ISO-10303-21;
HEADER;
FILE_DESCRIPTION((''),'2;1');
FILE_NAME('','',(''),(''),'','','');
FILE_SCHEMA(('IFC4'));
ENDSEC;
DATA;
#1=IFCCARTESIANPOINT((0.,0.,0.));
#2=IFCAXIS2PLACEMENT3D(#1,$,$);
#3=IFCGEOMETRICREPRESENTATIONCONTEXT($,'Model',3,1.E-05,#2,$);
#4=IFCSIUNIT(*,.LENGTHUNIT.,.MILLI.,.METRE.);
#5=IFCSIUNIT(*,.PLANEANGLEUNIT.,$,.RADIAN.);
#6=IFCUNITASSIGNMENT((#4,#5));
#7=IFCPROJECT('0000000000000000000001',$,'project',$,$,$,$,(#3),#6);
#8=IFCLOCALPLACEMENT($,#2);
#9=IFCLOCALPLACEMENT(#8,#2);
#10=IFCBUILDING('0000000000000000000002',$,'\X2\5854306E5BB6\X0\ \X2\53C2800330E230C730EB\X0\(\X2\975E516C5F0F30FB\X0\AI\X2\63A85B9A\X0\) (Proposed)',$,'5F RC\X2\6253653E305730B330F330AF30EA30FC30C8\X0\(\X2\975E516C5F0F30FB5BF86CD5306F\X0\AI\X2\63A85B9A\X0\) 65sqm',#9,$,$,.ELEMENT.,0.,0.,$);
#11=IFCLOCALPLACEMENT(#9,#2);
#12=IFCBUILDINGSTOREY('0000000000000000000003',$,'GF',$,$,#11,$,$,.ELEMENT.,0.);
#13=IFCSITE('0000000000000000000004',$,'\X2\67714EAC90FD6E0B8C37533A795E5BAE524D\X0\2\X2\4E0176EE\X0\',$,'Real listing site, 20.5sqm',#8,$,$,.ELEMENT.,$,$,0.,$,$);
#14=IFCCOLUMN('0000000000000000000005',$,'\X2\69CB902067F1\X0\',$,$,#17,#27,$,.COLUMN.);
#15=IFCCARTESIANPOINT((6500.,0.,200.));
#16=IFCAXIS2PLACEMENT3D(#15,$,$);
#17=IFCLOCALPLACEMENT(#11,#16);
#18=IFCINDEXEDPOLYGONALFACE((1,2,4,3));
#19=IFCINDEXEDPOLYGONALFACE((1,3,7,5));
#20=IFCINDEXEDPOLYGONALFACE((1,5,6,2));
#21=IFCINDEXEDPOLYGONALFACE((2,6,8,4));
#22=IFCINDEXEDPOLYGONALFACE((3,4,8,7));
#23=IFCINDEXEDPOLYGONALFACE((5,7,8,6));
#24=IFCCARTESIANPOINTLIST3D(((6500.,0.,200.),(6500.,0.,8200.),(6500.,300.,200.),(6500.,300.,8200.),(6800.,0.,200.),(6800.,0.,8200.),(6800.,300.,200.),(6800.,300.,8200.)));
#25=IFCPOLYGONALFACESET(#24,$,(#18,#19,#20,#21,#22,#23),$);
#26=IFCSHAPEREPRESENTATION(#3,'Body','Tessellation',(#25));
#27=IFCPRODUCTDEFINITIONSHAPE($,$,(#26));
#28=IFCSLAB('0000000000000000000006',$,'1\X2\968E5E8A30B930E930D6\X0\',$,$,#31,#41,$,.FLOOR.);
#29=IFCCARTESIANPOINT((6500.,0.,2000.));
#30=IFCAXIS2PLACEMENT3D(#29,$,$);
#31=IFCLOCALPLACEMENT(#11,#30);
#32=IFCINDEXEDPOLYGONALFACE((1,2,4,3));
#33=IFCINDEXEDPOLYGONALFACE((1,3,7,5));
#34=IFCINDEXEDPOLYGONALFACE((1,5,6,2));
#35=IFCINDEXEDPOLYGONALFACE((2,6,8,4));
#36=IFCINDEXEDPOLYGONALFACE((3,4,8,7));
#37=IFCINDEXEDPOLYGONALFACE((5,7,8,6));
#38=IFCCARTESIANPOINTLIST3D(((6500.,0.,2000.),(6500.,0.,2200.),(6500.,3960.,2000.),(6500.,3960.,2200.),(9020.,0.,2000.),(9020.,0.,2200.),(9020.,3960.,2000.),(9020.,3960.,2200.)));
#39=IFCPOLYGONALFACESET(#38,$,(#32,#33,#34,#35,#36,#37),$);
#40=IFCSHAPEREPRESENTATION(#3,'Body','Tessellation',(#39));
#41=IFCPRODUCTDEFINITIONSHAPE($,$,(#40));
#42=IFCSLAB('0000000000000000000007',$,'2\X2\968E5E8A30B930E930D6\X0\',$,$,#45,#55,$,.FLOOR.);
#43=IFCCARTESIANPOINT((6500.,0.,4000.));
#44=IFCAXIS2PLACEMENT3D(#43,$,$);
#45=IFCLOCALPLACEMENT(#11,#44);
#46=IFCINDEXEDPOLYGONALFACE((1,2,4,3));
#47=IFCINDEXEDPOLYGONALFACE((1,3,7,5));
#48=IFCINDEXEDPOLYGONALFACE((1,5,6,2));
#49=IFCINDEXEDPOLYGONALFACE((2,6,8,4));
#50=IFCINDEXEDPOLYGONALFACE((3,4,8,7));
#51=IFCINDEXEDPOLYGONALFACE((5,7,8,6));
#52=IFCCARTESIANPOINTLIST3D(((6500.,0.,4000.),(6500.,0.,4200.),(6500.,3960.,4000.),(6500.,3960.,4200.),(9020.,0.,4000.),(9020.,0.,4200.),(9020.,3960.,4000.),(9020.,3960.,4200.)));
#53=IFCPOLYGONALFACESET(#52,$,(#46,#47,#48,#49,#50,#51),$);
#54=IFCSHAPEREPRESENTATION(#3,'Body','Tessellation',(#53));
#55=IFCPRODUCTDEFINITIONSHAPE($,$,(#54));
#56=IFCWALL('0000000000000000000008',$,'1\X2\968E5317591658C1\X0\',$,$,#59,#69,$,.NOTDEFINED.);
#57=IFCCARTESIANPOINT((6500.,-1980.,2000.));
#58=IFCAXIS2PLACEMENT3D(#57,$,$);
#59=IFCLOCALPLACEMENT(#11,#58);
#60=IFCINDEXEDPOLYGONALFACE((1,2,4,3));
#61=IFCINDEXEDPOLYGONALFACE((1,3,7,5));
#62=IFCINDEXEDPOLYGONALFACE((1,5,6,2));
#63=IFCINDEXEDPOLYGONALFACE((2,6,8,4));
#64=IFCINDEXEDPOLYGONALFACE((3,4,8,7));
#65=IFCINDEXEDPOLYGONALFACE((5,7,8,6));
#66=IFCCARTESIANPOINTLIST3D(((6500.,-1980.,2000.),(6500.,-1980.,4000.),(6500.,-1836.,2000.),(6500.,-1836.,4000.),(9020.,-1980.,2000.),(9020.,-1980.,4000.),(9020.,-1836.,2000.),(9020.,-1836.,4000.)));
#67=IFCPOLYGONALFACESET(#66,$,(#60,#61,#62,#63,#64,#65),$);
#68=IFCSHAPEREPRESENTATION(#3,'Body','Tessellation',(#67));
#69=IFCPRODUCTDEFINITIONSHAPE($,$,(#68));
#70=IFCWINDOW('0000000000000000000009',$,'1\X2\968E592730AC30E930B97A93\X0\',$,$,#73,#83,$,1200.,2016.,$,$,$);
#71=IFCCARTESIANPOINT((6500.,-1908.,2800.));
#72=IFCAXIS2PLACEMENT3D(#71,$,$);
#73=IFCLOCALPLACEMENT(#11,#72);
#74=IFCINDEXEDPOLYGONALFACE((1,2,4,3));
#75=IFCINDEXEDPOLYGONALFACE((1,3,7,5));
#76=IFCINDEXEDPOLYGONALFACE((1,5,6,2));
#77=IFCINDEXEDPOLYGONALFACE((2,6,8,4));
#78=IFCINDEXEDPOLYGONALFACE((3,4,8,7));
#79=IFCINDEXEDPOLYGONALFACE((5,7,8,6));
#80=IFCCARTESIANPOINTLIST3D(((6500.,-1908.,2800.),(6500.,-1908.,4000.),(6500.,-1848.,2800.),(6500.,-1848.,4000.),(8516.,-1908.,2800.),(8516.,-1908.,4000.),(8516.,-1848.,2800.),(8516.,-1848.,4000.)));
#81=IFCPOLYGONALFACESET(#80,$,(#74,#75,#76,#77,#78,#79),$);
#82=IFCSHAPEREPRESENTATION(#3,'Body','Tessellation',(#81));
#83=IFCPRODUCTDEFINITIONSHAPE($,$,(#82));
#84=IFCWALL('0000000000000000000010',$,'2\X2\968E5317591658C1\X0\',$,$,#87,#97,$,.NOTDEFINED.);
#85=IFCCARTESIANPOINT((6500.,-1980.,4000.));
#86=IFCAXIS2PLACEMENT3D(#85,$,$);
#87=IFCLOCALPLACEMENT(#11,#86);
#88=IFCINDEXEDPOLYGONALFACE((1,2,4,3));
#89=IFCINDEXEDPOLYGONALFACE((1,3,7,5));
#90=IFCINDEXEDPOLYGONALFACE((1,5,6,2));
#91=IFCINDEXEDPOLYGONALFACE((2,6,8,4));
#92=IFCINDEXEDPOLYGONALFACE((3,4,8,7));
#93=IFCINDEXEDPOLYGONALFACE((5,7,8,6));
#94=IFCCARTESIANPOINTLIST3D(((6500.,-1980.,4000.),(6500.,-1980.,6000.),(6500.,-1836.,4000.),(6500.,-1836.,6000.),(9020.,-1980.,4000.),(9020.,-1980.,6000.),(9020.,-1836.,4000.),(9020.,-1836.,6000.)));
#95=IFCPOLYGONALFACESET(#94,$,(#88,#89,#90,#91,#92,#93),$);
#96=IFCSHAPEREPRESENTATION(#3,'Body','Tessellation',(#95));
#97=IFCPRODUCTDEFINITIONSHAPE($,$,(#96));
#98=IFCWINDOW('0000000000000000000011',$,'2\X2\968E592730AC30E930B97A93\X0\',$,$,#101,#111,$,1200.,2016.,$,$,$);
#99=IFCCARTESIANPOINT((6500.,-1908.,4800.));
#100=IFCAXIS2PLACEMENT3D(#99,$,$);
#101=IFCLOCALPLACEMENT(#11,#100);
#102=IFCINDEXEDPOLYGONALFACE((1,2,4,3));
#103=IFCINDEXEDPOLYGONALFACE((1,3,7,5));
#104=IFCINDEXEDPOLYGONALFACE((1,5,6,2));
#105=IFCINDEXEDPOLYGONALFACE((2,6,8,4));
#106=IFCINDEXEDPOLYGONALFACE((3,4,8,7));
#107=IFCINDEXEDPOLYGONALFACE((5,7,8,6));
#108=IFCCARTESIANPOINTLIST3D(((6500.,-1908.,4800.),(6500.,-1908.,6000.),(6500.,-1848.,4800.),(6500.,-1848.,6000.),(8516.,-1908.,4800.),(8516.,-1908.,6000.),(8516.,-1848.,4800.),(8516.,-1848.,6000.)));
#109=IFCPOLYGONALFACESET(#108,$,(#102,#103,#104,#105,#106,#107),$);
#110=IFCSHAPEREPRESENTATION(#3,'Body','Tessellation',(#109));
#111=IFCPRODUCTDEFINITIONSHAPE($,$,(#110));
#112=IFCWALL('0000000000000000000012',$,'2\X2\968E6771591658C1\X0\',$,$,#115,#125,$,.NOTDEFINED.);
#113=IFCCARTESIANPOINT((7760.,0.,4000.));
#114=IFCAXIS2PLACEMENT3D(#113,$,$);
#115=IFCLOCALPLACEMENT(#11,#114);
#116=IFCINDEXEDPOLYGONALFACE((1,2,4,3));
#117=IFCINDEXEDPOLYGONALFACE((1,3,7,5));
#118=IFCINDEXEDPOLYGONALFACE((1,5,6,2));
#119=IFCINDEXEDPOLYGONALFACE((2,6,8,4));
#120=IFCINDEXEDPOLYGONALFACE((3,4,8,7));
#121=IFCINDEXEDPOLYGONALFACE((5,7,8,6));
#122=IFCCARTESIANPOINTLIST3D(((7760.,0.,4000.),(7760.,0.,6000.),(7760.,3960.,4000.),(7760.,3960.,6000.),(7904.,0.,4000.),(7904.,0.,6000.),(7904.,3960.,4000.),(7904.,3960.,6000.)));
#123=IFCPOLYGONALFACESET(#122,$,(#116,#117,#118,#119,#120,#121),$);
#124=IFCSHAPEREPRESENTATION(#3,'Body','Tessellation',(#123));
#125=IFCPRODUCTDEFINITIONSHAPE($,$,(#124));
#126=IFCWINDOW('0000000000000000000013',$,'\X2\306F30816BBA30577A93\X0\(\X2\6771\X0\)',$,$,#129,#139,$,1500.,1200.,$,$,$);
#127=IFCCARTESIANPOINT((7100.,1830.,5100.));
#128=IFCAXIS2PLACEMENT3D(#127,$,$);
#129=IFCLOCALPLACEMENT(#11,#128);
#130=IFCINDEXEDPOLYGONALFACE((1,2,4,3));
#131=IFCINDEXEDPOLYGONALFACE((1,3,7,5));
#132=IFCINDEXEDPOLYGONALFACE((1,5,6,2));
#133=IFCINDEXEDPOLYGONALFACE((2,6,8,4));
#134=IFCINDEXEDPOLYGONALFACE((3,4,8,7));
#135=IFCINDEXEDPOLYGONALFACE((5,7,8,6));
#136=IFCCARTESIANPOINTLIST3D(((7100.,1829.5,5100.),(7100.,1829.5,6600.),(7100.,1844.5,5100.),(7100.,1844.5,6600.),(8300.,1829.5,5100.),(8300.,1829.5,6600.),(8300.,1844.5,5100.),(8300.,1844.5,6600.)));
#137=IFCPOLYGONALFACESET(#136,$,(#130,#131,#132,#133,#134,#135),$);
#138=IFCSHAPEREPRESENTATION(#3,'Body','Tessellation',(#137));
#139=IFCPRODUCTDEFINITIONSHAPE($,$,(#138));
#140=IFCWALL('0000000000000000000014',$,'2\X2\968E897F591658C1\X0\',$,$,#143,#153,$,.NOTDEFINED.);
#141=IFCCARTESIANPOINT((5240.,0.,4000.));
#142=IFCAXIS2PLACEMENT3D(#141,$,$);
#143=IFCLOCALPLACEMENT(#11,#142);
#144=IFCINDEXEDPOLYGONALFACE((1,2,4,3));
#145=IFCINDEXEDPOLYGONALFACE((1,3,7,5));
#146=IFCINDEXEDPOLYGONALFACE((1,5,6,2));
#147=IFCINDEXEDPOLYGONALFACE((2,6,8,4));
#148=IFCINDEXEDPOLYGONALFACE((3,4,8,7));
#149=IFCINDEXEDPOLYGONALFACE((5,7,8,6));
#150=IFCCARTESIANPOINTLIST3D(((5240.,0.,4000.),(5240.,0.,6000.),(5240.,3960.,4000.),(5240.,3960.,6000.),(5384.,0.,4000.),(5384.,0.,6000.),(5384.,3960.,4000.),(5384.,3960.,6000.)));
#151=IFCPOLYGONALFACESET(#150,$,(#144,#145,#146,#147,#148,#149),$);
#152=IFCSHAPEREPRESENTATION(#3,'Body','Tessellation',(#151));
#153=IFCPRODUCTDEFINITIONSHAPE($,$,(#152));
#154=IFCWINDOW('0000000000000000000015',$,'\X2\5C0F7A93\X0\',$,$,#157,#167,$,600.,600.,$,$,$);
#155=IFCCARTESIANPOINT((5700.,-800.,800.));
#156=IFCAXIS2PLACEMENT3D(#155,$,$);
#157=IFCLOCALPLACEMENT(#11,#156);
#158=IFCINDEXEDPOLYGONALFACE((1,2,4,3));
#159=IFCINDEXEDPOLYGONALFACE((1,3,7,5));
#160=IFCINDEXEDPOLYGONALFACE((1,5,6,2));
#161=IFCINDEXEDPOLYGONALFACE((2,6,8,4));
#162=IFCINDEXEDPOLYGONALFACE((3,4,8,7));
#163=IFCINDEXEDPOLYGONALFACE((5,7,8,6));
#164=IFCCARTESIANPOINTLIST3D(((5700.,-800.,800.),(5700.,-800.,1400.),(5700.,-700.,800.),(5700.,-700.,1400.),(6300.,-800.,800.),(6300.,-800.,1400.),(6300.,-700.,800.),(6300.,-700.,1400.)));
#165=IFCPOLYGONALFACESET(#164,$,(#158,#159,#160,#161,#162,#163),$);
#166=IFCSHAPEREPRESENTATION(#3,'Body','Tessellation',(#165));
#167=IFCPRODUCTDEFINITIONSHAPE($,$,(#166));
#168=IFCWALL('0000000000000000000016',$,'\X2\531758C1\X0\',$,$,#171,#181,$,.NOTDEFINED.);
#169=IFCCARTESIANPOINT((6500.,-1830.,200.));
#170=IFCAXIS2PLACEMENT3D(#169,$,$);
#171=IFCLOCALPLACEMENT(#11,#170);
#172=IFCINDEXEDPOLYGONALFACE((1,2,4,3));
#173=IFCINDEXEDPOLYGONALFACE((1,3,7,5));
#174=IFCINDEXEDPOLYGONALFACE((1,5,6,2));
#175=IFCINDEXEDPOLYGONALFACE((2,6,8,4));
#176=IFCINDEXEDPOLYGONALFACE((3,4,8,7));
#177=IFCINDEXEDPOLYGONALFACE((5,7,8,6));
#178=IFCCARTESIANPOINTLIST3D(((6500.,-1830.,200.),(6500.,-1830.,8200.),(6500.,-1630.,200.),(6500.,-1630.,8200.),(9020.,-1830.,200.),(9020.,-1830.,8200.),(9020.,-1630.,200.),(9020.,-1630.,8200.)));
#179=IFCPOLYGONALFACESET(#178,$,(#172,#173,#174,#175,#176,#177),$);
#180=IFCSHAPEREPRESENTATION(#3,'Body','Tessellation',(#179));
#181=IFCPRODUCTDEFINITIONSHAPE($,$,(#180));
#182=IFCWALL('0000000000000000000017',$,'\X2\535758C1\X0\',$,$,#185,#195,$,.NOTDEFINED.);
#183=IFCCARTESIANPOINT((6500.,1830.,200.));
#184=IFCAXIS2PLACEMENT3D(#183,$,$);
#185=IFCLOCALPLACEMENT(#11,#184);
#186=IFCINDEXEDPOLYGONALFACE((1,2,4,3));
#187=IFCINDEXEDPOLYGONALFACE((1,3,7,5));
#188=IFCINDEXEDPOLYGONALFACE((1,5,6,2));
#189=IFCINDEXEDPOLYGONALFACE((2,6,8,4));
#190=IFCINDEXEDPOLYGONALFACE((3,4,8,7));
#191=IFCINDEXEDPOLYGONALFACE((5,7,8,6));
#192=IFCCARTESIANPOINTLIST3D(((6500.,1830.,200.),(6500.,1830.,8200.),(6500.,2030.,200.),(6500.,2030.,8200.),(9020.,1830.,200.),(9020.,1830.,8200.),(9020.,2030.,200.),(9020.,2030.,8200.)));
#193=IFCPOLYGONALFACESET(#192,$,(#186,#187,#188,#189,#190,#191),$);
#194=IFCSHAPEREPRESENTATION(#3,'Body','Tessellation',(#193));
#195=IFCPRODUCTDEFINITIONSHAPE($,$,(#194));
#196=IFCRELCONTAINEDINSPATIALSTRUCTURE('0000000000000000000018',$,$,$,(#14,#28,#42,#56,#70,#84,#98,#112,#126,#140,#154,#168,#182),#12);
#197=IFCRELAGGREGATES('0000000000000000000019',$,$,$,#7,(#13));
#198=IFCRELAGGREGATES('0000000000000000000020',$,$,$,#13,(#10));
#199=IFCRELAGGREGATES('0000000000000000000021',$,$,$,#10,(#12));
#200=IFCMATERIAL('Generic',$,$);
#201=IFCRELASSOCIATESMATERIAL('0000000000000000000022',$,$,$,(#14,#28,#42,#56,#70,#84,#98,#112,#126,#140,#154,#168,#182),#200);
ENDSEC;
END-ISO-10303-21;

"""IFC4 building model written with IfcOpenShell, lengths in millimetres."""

from ifc_helpers import new_model, si_unit, frame, frame_2d, origin, place, context, project, spatial, rectangle, extrude, material, element, fill, save


model = new_model("IFC4")

# Units and contexts
model_context = context("Model", 3, precision=1e-05, world=origin())
ifc_project = project(units=[si_unit("LENGTHUNIT", "METRE", prefix="MILLI"), si_unit("PLANEANGLEUNIT", "RADIAN")], contexts=[model_context])

# Site, building, storey
site_placement = place(None, origin())
site = spatial("IfcSite", under=ifc_project, at=site_placement, Name="東京都渋谷区神宮前2丁目", ObjectType="Real listing site, 20.5sqm", CompositionType="ELEMENT", RefElevation=0.0)
building_placement = place(site_placement, origin())
building = spatial("IfcBuilding", under=site, at=building_placement, Name="塔の家 参考モデル(非公式・AI推定) (Proposed)", ObjectType="5F RC打放しコンクリート(非公式・寸法はAI推定) 65sqm", CompositionType="ELEMENT", ElevationOfRefHeight=0.0, ElevationOfTerrain=0.0)
storey_placement = place(building_placement, origin())
storey = spatial("IfcBuildingStorey", under=building, at=storey_placement, Name="GF", CompositionType="ELEMENT", Elevation=0.0)

# Column
ifc_material = material(Name="Generic")
column_placement = place(storey_placement, frame((6500.0, 0.0, 200.0)))
element("IfcColumn", 1, at=column_placement, inside=storey, material=ifc_material, Name="構造柱", PredefinedType="COLUMN", context=model_context, shape_type="SweptSolid", body=[
    extrude(rectangle(XDim=300.0, YDim=300.0, at=frame_2d((150.0, 150.0))), frame((6500.0, 0.0, 200.0)), (0.0, 0.0, 1.0), 8000.0),
])

# Slabs
slab_1_placement = place(storey_placement, frame((6500.0, 0.0, 2000.0)))
element("IfcSlab", 2, at=slab_1_placement, inside=storey, material=ifc_material, Name="1階床スラブ", PredefinedType="FLOOR", context=model_context, shape_type="SweptSolid", body=[
    extrude(rectangle(XDim=2520.0, YDim=3960.0, at=frame_2d((1260.0, 1980.0))), frame((6500.0, 0.0, 2000.0)), (0.0, 0.0, 1.0), 200.0),
])
slab_2_placement = place(storey_placement, frame((6500.0, 0.0, 4000.0)))
element("IfcSlab", 3, at=slab_2_placement, inside=storey, material=ifc_material, Name="2階床スラブ", PredefinedType="FLOOR", context=model_context, shape_type="SweptSolid", body=[
    extrude(rectangle(XDim=2520.0, YDim=3960.0, at=frame_2d((1260.0, 1980.0))), frame((6500.0, 0.0, 4000.0)), (0.0, 0.0, 1.0), 200.0),
])

# Wall, opening, window
wall_1_placement = place(storey_placement, frame((6500.0, -1980.0, 2000.0)))
wall_1 = element("IfcWall", 4, at=wall_1_placement, inside=storey, material=ifc_material, Name="1階北外壁", PredefinedType="NOTDEFINED", context=model_context, shape_type="SweptSolid", body=[
    extrude(rectangle(XDim=2520.0, YDim=144.0, at=frame_2d((1260.0, 72.0))), frame((6500.0, -1980.0, 2000.0)), (0.0, 0.0, 1.0), 2000.0),
])
opening_1_placement = place(storey_placement, frame((6500.0, -1908.0, 2800.0)))
opening_1 = element("IfcOpeningElement", 5, at=opening_1_placement, cuts=wall_1, PredefinedType="NOTDEFINED", context=model_context, shape_type="SweptSolid", body=[
    extrude(rectangle(XDim=2016.0, YDim=60.0, at=frame_2d((1008.0, 30.0))), frame((6500.0, -1908.0, 2800.0)), (0.0, 0.0, 1.0), 1200.0),
])
window_1_placement = place(storey_placement, frame((6500.0, -1908.0, 2800.0)))
window_1 = element("IfcWindow", 6, at=window_1_placement, inside=storey, material=ifc_material, Name="1階大ガラス窓", OverallHeight=1200.0, OverallWidth=2016.0, context=model_context, shape_type="SweptSolid", body=[
    extrude(rectangle(XDim=2016.0, YDim=60.0, at=frame_2d((1008.0, 30.0))), frame((6500.0, -1908.0, 2800.0)), (0.0, 0.0, 1.0), 1200.0),
])
fill(opening_1, window_1)

# Walls, openings, windows
wall_2_placement = place(storey_placement, frame((6500.0, -1980.0, 4000.0)))
wall_2 = element("IfcWall", 7, at=wall_2_placement, inside=storey, material=ifc_material, Name="2階北外壁", PredefinedType="NOTDEFINED", context=model_context, shape_type="SweptSolid", body=[
    extrude(rectangle(XDim=2520.0, YDim=144.0, at=frame_2d((1260.0, 72.0))), frame((6500.0, -1980.0, 4000.0)), (0.0, 0.0, 1.0), 2000.0),
])
opening_2_placement = place(storey_placement, frame((6500.0, -1908.0, 4800.0)))
opening_2 = element("IfcOpeningElement", 8, at=opening_2_placement, cuts=wall_2, PredefinedType="NOTDEFINED", context=model_context, shape_type="SweptSolid", body=[
    extrude(rectangle(XDim=2016.0, YDim=60.0, at=frame_2d((1008.0, 30.0))), frame((6500.0, -1908.0, 4800.0)), (0.0, 0.0, 1.0), 1200.0),
])
window_2_placement = place(storey_placement, frame((6500.0, -1908.0, 4800.0)))
window_2 = element("IfcWindow", 9, at=window_2_placement, inside=storey, material=ifc_material, Name="2階大ガラス窓", OverallHeight=1200.0, OverallWidth=2016.0, context=model_context, shape_type="SweptSolid", body=[
    extrude(rectangle(XDim=2016.0, YDim=60.0, at=frame_2d((1008.0, 30.0))), frame((6500.0, -1908.0, 4800.0)), (0.0, 0.0, 1.0), 1200.0),
])
fill(opening_2, window_2)
wall_3_placement = place(storey_placement, frame((7760.0, 0.0, 4000.0)))
wall_3 = element("IfcWall", 10, at=wall_3_placement, inside=storey, material=ifc_material, Name="2階東外壁", PredefinedType="NOTDEFINED", context=model_context, shape_type="SweptSolid", body=[
    extrude(rectangle(XDim=144.0, YDim=3960.0, at=frame_2d((72.0, 1980.0))), frame((7760.0, 0.0, 4000.0)), (0.0, 0.0, 1.0), 2000.0),
])
opening_3_placement = place(storey_placement, frame((7100.0, 1830.0, 5100.0)))
opening_3 = element("IfcOpeningElement", 11, at=opening_3_placement, cuts=wall_3, PredefinedType="NOTDEFINED", context=model_context, shape_type="SweptSolid", body=[
    extrude(rectangle(XDim=1200.0, YDim=15.0, at=frame_2d((600.0, 7.0))), frame((7100.0, 1830.0, 5100.0)), (0.0, 0.0, 1.0), 1500.0),
])
window_3_placement = place(storey_placement, frame((7100.0, 1830.0, 5100.0)))
window_3 = element("IfcWindow", 12, at=window_3_placement, inside=storey, material=ifc_material, Name="はめ殺し窓(東)", OverallHeight=1500.0, OverallWidth=1200.0, context=model_context, shape_type="SweptSolid", body=[
    extrude(rectangle(XDim=1200.0, YDim=15.0, at=frame_2d((600.0, 7.0))), frame((7100.0, 1830.0, 5100.0)), (0.0, 0.0, 1.0), 1500.0),
])
fill(opening_3, window_3)

# Wall
wall_4_placement = place(storey_placement, frame((5240.0, 0.0, 4000.0)))
element("IfcWall", 13, at=wall_4_placement, inside=storey, material=ifc_material, Name="2階西外壁", PredefinedType="NOTDEFINED", context=model_context, shape_type="SweptSolid", body=[
    extrude(rectangle(XDim=144.0, YDim=3960.0, at=frame_2d((72.0, 1980.0))), frame((5240.0, 0.0, 4000.0)), (0.0, 0.0, 1.0), 2000.0),
])

# Window
window_4_placement = place(storey_placement, frame((5700.0, -800.0, 800.0)))
element("IfcWindow", 14, at=window_4_placement, inside=storey, material=ifc_material, Name="小窓", OverallHeight=600.0, OverallWidth=600.0, context=model_context, shape_type="SweptSolid", body=[
    extrude(rectangle(XDim=600.0, YDim=100.0, at=frame_2d((300.0, 50.0))), frame((5700.0, -800.0, 800.0)), (0.0, 0.0, 1.0), 600.0),
])

# Walls
wall_5_placement = place(storey_placement, frame((6500.0, -1830.0, 200.0)))
element("IfcWall", 15, at=wall_5_placement, inside=storey, material=ifc_material, Name="北壁", PredefinedType="NOTDEFINED", context=model_context, shape_type="SweptSolid", body=[
    extrude(rectangle(XDim=2520.0, YDim=200.0, at=frame_2d((1260.0, 100.0))), frame((6500.0, -1830.0, 200.0)), (0.0, 0.0, 1.0), 8000.0),
])
wall_6_placement = place(storey_placement, frame((6500.0, 1830.0, 200.0)))
element("IfcWall", 16, at=wall_6_placement, inside=storey, material=ifc_material, Name="南壁", PredefinedType="NOTDEFINED", context=model_context, shape_type="SweptSolid", body=[
    extrude(rectangle(XDim=2520.0, YDim=200.0, at=frame_2d((1260.0, 100.0))), frame((6500.0, 1830.0, 200.0)), (0.0, 0.0, 1.0), 8000.0),
])

save(model, "model.ifc")
